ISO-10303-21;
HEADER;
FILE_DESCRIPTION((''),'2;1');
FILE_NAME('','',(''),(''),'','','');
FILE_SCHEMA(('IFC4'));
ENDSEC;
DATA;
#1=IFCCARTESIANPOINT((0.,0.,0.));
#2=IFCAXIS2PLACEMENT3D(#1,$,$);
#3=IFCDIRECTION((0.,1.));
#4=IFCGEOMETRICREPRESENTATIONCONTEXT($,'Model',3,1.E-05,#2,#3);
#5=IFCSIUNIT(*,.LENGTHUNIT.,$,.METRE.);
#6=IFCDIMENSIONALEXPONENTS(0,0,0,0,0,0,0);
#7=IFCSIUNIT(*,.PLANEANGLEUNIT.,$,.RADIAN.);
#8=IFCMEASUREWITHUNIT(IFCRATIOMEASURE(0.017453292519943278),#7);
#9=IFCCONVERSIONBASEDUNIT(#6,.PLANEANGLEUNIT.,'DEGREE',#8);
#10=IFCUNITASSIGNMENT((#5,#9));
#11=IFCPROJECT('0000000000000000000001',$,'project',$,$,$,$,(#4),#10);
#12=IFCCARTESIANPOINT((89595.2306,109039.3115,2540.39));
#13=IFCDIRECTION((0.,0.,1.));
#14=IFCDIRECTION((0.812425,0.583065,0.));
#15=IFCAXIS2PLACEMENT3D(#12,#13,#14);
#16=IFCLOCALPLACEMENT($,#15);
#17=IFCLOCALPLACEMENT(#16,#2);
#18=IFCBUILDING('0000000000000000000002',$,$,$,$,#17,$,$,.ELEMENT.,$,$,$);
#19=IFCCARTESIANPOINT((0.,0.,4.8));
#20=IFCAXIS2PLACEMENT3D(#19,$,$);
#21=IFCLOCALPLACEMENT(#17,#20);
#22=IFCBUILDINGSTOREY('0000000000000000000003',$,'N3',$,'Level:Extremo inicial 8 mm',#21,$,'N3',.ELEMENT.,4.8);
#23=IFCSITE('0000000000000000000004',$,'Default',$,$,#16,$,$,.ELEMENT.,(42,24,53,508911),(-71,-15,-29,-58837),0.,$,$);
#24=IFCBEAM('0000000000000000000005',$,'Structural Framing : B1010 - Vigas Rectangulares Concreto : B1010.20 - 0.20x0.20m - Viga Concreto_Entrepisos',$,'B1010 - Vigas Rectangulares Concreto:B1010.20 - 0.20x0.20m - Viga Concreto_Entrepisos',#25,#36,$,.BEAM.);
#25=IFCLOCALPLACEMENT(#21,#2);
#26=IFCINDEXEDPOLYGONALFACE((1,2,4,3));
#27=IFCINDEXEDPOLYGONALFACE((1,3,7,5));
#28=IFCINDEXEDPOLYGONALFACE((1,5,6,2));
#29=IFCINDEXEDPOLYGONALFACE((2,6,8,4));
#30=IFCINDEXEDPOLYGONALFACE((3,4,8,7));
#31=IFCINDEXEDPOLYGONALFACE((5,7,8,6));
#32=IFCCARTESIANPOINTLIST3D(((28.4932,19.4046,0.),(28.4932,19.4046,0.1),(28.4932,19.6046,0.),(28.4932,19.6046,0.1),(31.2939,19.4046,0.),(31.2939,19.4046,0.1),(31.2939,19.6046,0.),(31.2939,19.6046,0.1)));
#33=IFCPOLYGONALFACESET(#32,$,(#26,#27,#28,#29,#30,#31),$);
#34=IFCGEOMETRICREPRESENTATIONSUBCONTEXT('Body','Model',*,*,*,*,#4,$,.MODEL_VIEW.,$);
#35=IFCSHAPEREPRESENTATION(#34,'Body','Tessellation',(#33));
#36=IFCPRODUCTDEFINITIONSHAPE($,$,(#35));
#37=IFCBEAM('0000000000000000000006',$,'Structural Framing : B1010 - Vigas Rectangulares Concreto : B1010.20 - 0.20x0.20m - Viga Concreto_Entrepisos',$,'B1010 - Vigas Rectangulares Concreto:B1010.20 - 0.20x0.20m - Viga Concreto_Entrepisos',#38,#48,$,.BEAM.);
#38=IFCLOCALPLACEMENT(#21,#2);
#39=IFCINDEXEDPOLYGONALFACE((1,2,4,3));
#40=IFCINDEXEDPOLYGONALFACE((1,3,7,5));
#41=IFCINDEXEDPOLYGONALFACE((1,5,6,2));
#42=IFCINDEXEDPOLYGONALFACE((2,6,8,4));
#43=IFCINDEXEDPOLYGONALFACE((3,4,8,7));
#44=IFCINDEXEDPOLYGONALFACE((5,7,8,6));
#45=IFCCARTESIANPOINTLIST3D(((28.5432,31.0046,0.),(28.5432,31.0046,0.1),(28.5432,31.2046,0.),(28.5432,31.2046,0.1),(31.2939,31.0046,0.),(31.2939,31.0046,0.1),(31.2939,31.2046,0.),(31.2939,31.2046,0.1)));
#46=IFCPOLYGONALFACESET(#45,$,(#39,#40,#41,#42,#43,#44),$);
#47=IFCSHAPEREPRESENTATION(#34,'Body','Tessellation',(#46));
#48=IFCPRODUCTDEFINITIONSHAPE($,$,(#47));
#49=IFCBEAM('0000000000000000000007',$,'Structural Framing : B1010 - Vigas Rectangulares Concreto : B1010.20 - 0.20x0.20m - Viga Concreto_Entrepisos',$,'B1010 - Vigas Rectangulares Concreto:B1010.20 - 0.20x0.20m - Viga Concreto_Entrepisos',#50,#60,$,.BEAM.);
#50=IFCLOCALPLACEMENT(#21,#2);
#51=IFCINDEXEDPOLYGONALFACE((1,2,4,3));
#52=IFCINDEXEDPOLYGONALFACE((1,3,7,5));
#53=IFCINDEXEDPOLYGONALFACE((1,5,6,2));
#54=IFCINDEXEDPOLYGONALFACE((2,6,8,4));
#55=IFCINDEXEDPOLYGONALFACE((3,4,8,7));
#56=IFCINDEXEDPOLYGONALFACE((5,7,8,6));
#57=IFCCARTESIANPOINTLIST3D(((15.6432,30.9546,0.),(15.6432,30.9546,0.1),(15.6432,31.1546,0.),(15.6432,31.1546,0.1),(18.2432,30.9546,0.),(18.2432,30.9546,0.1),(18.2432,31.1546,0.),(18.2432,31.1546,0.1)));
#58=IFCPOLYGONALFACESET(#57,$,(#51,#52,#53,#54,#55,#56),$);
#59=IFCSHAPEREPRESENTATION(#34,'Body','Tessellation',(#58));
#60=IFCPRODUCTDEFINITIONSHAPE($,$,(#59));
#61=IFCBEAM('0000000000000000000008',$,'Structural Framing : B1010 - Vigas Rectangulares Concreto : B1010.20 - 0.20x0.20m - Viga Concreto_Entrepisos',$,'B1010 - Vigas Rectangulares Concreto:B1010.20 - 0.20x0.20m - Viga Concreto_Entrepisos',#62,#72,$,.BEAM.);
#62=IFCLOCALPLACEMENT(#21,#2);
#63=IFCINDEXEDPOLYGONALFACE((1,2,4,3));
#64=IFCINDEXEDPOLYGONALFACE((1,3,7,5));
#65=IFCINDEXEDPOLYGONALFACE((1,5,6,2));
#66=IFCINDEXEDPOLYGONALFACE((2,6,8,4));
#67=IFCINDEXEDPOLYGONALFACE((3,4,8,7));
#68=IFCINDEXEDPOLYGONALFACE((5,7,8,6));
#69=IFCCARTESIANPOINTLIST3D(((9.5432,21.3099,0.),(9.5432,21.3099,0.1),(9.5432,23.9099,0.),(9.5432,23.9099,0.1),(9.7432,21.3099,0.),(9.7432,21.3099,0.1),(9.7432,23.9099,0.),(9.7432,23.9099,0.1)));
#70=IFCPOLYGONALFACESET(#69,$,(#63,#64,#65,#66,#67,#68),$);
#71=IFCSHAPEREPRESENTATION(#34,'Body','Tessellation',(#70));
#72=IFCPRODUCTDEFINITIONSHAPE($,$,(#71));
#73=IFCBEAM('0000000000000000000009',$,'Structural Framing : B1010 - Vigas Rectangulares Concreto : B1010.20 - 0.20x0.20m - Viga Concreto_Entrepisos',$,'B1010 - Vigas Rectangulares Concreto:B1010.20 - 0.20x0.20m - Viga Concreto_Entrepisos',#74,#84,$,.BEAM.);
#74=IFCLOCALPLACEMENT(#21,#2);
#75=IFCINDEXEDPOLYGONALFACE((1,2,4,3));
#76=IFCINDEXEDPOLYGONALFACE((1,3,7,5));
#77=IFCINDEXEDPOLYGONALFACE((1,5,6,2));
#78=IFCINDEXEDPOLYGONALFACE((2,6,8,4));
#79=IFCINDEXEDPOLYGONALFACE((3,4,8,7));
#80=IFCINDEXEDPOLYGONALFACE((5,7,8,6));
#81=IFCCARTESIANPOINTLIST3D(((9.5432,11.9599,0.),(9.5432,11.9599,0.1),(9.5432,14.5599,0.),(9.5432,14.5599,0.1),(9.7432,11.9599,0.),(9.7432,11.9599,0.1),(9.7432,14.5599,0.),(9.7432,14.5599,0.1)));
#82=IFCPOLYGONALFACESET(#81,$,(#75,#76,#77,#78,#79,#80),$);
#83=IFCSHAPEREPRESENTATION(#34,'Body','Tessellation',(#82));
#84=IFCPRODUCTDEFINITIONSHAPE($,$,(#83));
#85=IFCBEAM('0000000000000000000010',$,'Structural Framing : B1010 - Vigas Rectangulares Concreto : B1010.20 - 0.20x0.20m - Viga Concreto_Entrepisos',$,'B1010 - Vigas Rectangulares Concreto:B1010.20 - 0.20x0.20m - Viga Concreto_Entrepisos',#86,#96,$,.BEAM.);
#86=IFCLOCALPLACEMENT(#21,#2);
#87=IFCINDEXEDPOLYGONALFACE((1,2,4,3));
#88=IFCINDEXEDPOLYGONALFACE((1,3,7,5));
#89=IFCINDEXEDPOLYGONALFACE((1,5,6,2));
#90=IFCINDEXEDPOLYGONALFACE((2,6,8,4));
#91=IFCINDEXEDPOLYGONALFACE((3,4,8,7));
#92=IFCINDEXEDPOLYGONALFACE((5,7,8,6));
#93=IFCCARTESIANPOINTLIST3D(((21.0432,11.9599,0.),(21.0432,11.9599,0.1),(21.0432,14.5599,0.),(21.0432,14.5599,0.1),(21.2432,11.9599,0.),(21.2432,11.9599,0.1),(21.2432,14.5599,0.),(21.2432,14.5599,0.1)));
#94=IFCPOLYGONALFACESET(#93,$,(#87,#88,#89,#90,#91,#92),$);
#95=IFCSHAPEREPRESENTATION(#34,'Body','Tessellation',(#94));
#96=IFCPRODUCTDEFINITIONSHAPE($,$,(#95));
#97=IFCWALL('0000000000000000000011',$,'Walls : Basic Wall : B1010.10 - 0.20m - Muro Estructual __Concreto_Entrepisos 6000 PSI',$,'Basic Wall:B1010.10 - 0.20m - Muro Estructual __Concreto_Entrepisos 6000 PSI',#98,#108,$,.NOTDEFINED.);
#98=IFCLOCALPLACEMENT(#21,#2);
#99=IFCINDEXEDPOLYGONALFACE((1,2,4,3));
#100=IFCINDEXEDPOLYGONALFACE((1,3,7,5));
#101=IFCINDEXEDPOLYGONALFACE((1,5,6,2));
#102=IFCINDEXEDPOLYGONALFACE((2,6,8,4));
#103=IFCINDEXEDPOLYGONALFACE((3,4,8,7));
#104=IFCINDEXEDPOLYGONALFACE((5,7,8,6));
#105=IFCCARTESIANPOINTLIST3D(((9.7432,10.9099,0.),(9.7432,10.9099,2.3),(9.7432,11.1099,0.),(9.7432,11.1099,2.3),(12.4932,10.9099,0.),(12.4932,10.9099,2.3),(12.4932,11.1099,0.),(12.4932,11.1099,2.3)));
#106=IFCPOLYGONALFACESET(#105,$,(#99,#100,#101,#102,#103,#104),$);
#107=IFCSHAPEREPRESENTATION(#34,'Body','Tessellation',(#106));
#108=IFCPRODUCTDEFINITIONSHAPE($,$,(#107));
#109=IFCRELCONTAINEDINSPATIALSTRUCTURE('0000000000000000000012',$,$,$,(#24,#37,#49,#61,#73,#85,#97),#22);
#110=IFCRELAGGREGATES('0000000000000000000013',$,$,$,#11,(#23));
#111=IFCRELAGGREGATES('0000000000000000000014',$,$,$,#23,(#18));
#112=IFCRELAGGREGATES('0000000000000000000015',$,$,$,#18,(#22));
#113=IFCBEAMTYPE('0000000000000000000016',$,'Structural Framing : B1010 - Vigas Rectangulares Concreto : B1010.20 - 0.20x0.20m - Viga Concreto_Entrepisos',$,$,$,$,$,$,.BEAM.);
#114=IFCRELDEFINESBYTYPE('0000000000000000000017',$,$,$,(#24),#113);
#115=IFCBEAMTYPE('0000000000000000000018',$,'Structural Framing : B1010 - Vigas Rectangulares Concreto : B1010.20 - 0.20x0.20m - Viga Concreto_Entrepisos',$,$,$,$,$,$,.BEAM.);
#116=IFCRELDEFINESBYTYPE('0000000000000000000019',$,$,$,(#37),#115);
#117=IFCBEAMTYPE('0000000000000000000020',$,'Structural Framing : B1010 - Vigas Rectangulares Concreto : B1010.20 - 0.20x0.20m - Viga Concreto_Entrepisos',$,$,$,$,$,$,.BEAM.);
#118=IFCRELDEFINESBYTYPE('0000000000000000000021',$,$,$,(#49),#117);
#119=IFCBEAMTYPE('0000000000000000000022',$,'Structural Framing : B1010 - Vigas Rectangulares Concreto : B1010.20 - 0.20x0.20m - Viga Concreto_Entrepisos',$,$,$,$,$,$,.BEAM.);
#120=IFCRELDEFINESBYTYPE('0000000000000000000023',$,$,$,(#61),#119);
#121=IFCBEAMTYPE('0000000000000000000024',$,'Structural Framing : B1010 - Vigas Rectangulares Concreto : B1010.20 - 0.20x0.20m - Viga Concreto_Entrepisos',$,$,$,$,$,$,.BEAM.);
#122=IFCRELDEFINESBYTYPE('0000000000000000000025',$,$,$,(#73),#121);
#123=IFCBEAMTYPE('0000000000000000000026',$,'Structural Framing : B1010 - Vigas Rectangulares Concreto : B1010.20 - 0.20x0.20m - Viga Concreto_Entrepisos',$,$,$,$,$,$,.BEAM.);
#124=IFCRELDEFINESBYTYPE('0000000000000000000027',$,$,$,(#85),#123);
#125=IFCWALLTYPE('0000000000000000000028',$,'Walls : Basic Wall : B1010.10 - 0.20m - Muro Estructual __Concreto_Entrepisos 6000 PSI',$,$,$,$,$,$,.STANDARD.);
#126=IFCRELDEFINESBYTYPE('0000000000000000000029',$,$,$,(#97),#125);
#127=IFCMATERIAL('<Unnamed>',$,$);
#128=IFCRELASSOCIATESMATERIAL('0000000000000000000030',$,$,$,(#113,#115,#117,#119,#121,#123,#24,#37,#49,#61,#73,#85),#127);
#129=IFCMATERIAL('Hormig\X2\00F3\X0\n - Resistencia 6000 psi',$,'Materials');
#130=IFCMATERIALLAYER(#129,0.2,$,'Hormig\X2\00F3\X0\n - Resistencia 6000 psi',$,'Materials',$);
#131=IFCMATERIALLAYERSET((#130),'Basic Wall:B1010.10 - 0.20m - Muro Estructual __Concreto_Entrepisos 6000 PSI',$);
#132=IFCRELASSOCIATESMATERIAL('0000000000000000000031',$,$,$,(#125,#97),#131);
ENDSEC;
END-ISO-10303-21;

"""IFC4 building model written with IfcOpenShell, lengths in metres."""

from ifc_helpers import new_model, entity, si_unit, converted_unit, direction, frame, frame_2d, origin, place, context, subcontext, project, spatial, polyline, segment, composite_curve, rectangle, outline, extrude, source, transform, mapped, material, layer, layer_set, layer_usage, material_profile, profile_set, profile_usage, type_object, type_shapes, element, save


model = new_model("IFC4")

# Units and contexts
model_context = context("Model", 3, precision=1e-05, world=origin(), true_north=direction((0.0, 1.0)))
body_context = subcontext(model_context, "Body", "Model", "MODEL_VIEW")
ifc_project = project(units=[si_unit("LENGTHUNIT", "METRE"), converted_unit("PLANEANGLEUNIT", "DEGREE", entity("IfcRatioMeasure", 0.017453292519943278), si_unit("PLANEANGLEUNIT", "RADIAN"), dimensions=[0, 0, 0, 0, 0, 0, 0])], contexts=[model_context])

# Site, building, storey
site_placement = place(None, frame((89595.2306, 109039.3115, 2540.39), z_axis=(0.0, 0.0, 1.0), x_axis=(0.812425, 0.583065, 0.0)))
site = spatial("IfcSite", under=ifc_project, at=site_placement, Name="Default", CompositionType="ELEMENT", RefLatitude=(42, 24, 53, 508911), RefLongitude=(-71, -15, -29, -58837), RefElevation=0.0)
building_placement = place(site_placement, origin())
building = spatial("IfcBuilding", under=site, at=building_placement, CompositionType="ELEMENT")
storey_placement = place(building_placement, frame((0.0, 0.0, 4.8)))
storey = spatial("IfcBuildingStorey", under=building, at=storey_placement, Name="N3", ObjectType="Level:Extremo inicial 8 mm", LongName="N3", CompositionType="ELEMENT", Elevation=4.8)

# Beams
ifc_material_1 = material(Name="<Unnamed>")
ifc_material_profile_1 = material_profile(ifc_material_1, outline(composite_curve([segment(polyline([(-0.1, 0.0, 0.0), (-0.1, 0.1, 0.0)]), True, "CONTINUOUS"), segment(polyline([(-0.1, 0.1, 0.0), (0.1, 0.1, 0.0)]), True, "CONTINUOUS"), segment(polyline([(0.1, 0.1, 0.0), (0.1, 0.0, 0.0)]), True, "CONTINUOUS"), segment(polyline([(0.1, 0.0, 0.0), (-0.1, 0.0, 0.0)]), True, "CONTINUOUS")], self_intersect=False), kind="CURVE"), Name="B1010.20 - 0.20x0.20m - Viga Concreto_Entrepisos")
ifc_material_profile_2 = material_profile(ifc_material_1, outline(composite_curve([segment(polyline([(-1.4004, -0.1, 0.1), (-1.4004, 0.1, 0.1)]), True, "CONTINUOUS"), segment(polyline([(-1.4004, 0.1, 0.1), (-1.4004, 0.1, -0.1)]), True, "CONTINUOUS"), segment(polyline([(-1.4004, 0.1, -0.1), (-1.4004, -0.1, -0.1)]), True, "CONTINUOUS"), segment(polyline([(-1.4004, -0.1, -0.1), (-1.4004, -0.1, 0.1)]), True, "CONTINUOUS")], self_intersect=False), kind="CURVE"), Name="B1010.20 - 0.20x0.20m - Viga Concreto_Entrepisos")
ifc_profile_set_1 = profile_set([ifc_material_profile_1, ifc_material_profile_2], Name="B1010.20 - 0.20x0.20m - Viga Concreto_Entrepisos")
ifc_profile_usage_1 = profile_usage(ifc_profile_set_1, cardinal=8)
beam_type_1 = type_object("IfcBeamType", Name="Structural Framing : B1010 - Vigas Rectangulares Concreto : B1010.20 - 0.20x0.20m - Viga Concreto_Entrepisos", PredefinedType="BEAM", material=ifc_profile_set_1)
shared_shape_1 = source(origin(), body_context, "Body", "SweptSolid", [
    extrude(rectangle(XDim=0.1, YDim=0.2, at=frame_2d((0.0, 0.0), x_axis=(1.0, 0.0))), frame((31.2939, 19.5046, 4.85), z_axis=(-1.0, 0.0, 0.0), x_axis=(0.0, 0.0, -1.0)), (0.0, 0.0, 1.0), 2.8007),
])
type_shapes(beam_type_1, [shared_shape_1])
beam_1_placement = place(storey_placement, frame((0.0, 0.0, -4.8)))
element("IfcBeam", 1, at=beam_1_placement, inside=storey, type_object=beam_type_1, material=ifc_profile_usage_1, Name="Structural Framing : B1010 - Vigas Rectangulares Concreto : B1010.20 - 0.20x0.20m - Viga Concreto_Entrepisos", ObjectType="B1010 - Vigas Rectangulares Concreto:B1010.20 - 0.20x0.20m - Viga Concreto_Entrepisos", PredefinedType="BEAM", context=body_context, shape_type="MappedRepresentation", body=[
    mapped(shared_shape_1, transform((0.0, 0.0, 0.0), scale=1.0)),
])
ifc_profile_usage_2 = profile_usage(ifc_profile_set_1, cardinal=8)
beam_type_2 = type_object("IfcBeamType", Name="Structural Framing : B1010 - Vigas Rectangulares Concreto : B1010.20 - 0.20x0.20m - Viga Concreto_Entrepisos", PredefinedType="BEAM", material=ifc_profile_set_1)
shared_shape_2 = source(origin(), body_context, "Body", "SweptSolid", [
    extrude(rectangle(XDim=0.1, YDim=0.2, at=frame_2d((0.0, 0.0), x_axis=(1.0, 0.0))), frame((31.2939, 31.1046, 4.85), z_axis=(-1.0, 0.0, 0.0), x_axis=(0.0, 0.0, -1.0)), (0.0, 0.0, 1.0), 2.7507),
])
type_shapes(beam_type_2, [shared_shape_2])
beam_2_placement = place(storey_placement, frame((0.0, 0.0, -4.8)))
element("IfcBeam", 2, at=beam_2_placement, inside=storey, type_object=beam_type_2, material=ifc_profile_usage_2, Name="Structural Framing : B1010 - Vigas Rectangulares Concreto : B1010.20 - 0.20x0.20m - Viga Concreto_Entrepisos", ObjectType="B1010 - Vigas Rectangulares Concreto:B1010.20 - 0.20x0.20m - Viga Concreto_Entrepisos", PredefinedType="BEAM", context=body_context, shape_type="MappedRepresentation", body=[
    mapped(shared_shape_2, transform((0.0, 0.0, 0.0), scale=1.0)),
])
ifc_profile_usage_3 = profile_usage(ifc_profile_set_1, cardinal=8)
beam_type_3 = type_object("IfcBeamType", Name="Structural Framing : B1010 - Vigas Rectangulares Concreto : B1010.20 - 0.20x0.20m - Viga Concreto_Entrepisos", PredefinedType="BEAM", material=ifc_profile_set_1)
shared_shape_3 = source(origin(), body_context, "Body", "SweptSolid", [
    extrude(rectangle(XDim=0.1, YDim=0.2, at=frame_2d((0.0, 0.0), x_axis=(1.0, 0.0))), frame((18.2432, 31.0546, 4.85), z_axis=(-1.0, 0.0, 0.0), x_axis=(0.0, 0.0, -1.0)), (0.0, 0.0, 1.0), 2.6),
])
type_shapes(beam_type_3, [shared_shape_3])
beam_3_placement = place(storey_placement, frame((0.0, 0.0, -4.8)))
element("IfcBeam", 3, at=beam_3_placement, inside=storey, type_object=beam_type_3, material=ifc_profile_usage_3, Name="Structural Framing : B1010 - Vigas Rectangulares Concreto : B1010.20 - 0.20x0.20m - Viga Concreto_Entrepisos", ObjectType="B1010 - Vigas Rectangulares Concreto:B1010.20 - 0.20x0.20m - Viga Concreto_Entrepisos", PredefinedType="BEAM", context=body_context, shape_type="MappedRepresentation", body=[
    mapped(shared_shape_3, transform((0.0, 0.0, 0.0), scale=1.0)),
])
ifc_profile_usage_4 = profile_usage(ifc_profile_set_1, cardinal=8)
beam_type_4 = type_object("IfcBeamType", Name="Structural Framing : B1010 - Vigas Rectangulares Concreto : B1010.20 - 0.20x0.20m - Viga Concreto_Entrepisos", PredefinedType="BEAM", material=ifc_profile_set_1)
shared_shape_4 = source(origin(), body_context, "Body", "SweptSolid", [
    extrude(rectangle(XDim=0.1, YDim=0.2, at=frame_2d((0.0, 0.0), x_axis=(0.0, 1.0))), frame((9.6432, 21.3099, 4.85), z_axis=(0.0, 1.0, 0.0), x_axis=(-1.0, 0.0, 0.0)), (0.0, 0.0, 1.0), 2.6),
])
type_shapes(beam_type_4, [shared_shape_4])
beam_4_placement = place(storey_placement, frame((0.0, 0.0, -4.8)))
element("IfcBeam", 4, at=beam_4_placement, inside=storey, type_object=beam_type_4, material=ifc_profile_usage_4, Name="Structural Framing : B1010 - Vigas Rectangulares Concreto : B1010.20 - 0.20x0.20m - Viga Concreto_Entrepisos", ObjectType="B1010 - Vigas Rectangulares Concreto:B1010.20 - 0.20x0.20m - Viga Concreto_Entrepisos", PredefinedType="BEAM", context=body_context, shape_type="MappedRepresentation", body=[
    mapped(shared_shape_4, transform((0.0, 0.0, 0.0), scale=1.0)),
])
ifc_profile_usage_5 = profile_usage(ifc_profile_set_1, cardinal=8)
beam_type_5 = type_object("IfcBeamType", Name="Structural Framing : B1010 - Vigas Rectangulares Concreto : B1010.20 - 0.20x0.20m - Viga Concreto_Entrepisos", PredefinedType="BEAM", material=ifc_profile_set_1)
shared_shape_5 = source(origin(), body_context, "Body", "SweptSolid", [
    extrude(rectangle(XDim=0.1, YDim=0.2, at=frame_2d((0.0, 0.0), x_axis=(0.0, 1.0))), frame((9.6432, 11.9599, 4.85), z_axis=(0.0, 1.0, 0.0), x_axis=(-1.0, 0.0, 0.0)), (0.0, 0.0, 1.0), 2.6),
])
type_shapes(beam_type_5, [shared_shape_5])
beam_5_placement = place(storey_placement, frame((0.0, 0.0, -4.8)))
element("IfcBeam", 5, at=beam_5_placement, inside=storey, type_object=beam_type_5, material=ifc_profile_usage_5, Name="Structural Framing : B1010 - Vigas Rectangulares Concreto : B1010.20 - 0.20x0.20m - Viga Concreto_Entrepisos", ObjectType="B1010 - Vigas Rectangulares Concreto:B1010.20 - 0.20x0.20m - Viga Concreto_Entrepisos", PredefinedType="BEAM", context=body_context, shape_type="MappedRepresentation", body=[
    mapped(shared_shape_5, transform((0.0, 0.0, 0.0), scale=1.0)),
])
ifc_profile_usage_6 = profile_usage(ifc_profile_set_1, cardinal=8)
beam_type_6 = type_object("IfcBeamType", Name="Structural Framing : B1010 - Vigas Rectangulares Concreto : B1010.20 - 0.20x0.20m - Viga Concreto_Entrepisos", PredefinedType="BEAM", material=ifc_profile_set_1)
shared_shape_6 = source(origin(), body_context, "Body", "SweptSolid", [
    extrude(rectangle(XDim=0.1, YDim=0.2, at=frame_2d((0.0, 0.0), x_axis=(0.0, 1.0))), frame((21.1432, 11.9599, 4.85), z_axis=(0.0, 1.0, 0.0), x_axis=(-1.0, 0.0, 0.0)), (0.0, 0.0, 1.0), 2.6),
])
type_shapes(beam_type_6, [shared_shape_6])
beam_6_placement = place(storey_placement, frame((0.0, 0.0, -4.8)))
element("IfcBeam", 6, at=beam_6_placement, inside=storey, type_object=beam_type_6, material=ifc_profile_usage_6, Name="Structural Framing : B1010 - Vigas Rectangulares Concreto : B1010.20 - 0.20x0.20m - Viga Concreto_Entrepisos", ObjectType="B1010 - Vigas Rectangulares Concreto:B1010.20 - 0.20x0.20m - Viga Concreto_Entrepisos", PredefinedType="BEAM", context=body_context, shape_type="MappedRepresentation", body=[
    mapped(shared_shape_6, transform((0.0, 0.0, 0.0), scale=1.0)),
])

# Wall
ifc_material_2 = material(Name="Hormigón - Resistencia 6000 psi", Category="Materials")
ifc_layer_1 = layer(ifc_material_2, 0.2, Name="Hormigón - Resistencia 6000 psi", Category="Materials")
ifc_layer_set_1 = layer_set([ifc_layer_1], Name="Basic Wall:B1010.10 - 0.20m - Muro Estructual __Concreto_Entrepisos 6000 PSI")
ifc_layer_usage_1 = layer_usage(ifc_layer_set_1, "AXIS2", "POSITIVE", -0.1)
wall_type = type_object("IfcWallType", Name="Walls : Basic Wall : B1010.10 - 0.20m - Muro Estructual __Concreto_Entrepisos 6000 PSI", PredefinedType="STANDARD", material=ifc_layer_set_1)
wall_placement = place(storey_placement, frame((9.7432, 11.0099, 0.0)))
element("IfcWall", 7, at=wall_placement, inside=storey, type_object=wall_type, material=ifc_layer_usage_1, Name="Walls : Basic Wall : B1010.10 - 0.20m - Muro Estructual __Concreto_Entrepisos 6000 PSI", ObjectType="Basic Wall:B1010.10 - 0.20m - Muro Estructual __Concreto_Entrepisos 6000 PSI", PredefinedType="NOTDEFINED", context=body_context, shape_type="SweptSolid", body=[
    extrude(rectangle(XDim=2.75, YDim=0.2, at=frame_2d((1.375, 0.0), x_axis=(-1.0, 0.0))), origin(), (0.0, 0.0, 1.0), 2.3),
])

save(model, "model.ifc")
